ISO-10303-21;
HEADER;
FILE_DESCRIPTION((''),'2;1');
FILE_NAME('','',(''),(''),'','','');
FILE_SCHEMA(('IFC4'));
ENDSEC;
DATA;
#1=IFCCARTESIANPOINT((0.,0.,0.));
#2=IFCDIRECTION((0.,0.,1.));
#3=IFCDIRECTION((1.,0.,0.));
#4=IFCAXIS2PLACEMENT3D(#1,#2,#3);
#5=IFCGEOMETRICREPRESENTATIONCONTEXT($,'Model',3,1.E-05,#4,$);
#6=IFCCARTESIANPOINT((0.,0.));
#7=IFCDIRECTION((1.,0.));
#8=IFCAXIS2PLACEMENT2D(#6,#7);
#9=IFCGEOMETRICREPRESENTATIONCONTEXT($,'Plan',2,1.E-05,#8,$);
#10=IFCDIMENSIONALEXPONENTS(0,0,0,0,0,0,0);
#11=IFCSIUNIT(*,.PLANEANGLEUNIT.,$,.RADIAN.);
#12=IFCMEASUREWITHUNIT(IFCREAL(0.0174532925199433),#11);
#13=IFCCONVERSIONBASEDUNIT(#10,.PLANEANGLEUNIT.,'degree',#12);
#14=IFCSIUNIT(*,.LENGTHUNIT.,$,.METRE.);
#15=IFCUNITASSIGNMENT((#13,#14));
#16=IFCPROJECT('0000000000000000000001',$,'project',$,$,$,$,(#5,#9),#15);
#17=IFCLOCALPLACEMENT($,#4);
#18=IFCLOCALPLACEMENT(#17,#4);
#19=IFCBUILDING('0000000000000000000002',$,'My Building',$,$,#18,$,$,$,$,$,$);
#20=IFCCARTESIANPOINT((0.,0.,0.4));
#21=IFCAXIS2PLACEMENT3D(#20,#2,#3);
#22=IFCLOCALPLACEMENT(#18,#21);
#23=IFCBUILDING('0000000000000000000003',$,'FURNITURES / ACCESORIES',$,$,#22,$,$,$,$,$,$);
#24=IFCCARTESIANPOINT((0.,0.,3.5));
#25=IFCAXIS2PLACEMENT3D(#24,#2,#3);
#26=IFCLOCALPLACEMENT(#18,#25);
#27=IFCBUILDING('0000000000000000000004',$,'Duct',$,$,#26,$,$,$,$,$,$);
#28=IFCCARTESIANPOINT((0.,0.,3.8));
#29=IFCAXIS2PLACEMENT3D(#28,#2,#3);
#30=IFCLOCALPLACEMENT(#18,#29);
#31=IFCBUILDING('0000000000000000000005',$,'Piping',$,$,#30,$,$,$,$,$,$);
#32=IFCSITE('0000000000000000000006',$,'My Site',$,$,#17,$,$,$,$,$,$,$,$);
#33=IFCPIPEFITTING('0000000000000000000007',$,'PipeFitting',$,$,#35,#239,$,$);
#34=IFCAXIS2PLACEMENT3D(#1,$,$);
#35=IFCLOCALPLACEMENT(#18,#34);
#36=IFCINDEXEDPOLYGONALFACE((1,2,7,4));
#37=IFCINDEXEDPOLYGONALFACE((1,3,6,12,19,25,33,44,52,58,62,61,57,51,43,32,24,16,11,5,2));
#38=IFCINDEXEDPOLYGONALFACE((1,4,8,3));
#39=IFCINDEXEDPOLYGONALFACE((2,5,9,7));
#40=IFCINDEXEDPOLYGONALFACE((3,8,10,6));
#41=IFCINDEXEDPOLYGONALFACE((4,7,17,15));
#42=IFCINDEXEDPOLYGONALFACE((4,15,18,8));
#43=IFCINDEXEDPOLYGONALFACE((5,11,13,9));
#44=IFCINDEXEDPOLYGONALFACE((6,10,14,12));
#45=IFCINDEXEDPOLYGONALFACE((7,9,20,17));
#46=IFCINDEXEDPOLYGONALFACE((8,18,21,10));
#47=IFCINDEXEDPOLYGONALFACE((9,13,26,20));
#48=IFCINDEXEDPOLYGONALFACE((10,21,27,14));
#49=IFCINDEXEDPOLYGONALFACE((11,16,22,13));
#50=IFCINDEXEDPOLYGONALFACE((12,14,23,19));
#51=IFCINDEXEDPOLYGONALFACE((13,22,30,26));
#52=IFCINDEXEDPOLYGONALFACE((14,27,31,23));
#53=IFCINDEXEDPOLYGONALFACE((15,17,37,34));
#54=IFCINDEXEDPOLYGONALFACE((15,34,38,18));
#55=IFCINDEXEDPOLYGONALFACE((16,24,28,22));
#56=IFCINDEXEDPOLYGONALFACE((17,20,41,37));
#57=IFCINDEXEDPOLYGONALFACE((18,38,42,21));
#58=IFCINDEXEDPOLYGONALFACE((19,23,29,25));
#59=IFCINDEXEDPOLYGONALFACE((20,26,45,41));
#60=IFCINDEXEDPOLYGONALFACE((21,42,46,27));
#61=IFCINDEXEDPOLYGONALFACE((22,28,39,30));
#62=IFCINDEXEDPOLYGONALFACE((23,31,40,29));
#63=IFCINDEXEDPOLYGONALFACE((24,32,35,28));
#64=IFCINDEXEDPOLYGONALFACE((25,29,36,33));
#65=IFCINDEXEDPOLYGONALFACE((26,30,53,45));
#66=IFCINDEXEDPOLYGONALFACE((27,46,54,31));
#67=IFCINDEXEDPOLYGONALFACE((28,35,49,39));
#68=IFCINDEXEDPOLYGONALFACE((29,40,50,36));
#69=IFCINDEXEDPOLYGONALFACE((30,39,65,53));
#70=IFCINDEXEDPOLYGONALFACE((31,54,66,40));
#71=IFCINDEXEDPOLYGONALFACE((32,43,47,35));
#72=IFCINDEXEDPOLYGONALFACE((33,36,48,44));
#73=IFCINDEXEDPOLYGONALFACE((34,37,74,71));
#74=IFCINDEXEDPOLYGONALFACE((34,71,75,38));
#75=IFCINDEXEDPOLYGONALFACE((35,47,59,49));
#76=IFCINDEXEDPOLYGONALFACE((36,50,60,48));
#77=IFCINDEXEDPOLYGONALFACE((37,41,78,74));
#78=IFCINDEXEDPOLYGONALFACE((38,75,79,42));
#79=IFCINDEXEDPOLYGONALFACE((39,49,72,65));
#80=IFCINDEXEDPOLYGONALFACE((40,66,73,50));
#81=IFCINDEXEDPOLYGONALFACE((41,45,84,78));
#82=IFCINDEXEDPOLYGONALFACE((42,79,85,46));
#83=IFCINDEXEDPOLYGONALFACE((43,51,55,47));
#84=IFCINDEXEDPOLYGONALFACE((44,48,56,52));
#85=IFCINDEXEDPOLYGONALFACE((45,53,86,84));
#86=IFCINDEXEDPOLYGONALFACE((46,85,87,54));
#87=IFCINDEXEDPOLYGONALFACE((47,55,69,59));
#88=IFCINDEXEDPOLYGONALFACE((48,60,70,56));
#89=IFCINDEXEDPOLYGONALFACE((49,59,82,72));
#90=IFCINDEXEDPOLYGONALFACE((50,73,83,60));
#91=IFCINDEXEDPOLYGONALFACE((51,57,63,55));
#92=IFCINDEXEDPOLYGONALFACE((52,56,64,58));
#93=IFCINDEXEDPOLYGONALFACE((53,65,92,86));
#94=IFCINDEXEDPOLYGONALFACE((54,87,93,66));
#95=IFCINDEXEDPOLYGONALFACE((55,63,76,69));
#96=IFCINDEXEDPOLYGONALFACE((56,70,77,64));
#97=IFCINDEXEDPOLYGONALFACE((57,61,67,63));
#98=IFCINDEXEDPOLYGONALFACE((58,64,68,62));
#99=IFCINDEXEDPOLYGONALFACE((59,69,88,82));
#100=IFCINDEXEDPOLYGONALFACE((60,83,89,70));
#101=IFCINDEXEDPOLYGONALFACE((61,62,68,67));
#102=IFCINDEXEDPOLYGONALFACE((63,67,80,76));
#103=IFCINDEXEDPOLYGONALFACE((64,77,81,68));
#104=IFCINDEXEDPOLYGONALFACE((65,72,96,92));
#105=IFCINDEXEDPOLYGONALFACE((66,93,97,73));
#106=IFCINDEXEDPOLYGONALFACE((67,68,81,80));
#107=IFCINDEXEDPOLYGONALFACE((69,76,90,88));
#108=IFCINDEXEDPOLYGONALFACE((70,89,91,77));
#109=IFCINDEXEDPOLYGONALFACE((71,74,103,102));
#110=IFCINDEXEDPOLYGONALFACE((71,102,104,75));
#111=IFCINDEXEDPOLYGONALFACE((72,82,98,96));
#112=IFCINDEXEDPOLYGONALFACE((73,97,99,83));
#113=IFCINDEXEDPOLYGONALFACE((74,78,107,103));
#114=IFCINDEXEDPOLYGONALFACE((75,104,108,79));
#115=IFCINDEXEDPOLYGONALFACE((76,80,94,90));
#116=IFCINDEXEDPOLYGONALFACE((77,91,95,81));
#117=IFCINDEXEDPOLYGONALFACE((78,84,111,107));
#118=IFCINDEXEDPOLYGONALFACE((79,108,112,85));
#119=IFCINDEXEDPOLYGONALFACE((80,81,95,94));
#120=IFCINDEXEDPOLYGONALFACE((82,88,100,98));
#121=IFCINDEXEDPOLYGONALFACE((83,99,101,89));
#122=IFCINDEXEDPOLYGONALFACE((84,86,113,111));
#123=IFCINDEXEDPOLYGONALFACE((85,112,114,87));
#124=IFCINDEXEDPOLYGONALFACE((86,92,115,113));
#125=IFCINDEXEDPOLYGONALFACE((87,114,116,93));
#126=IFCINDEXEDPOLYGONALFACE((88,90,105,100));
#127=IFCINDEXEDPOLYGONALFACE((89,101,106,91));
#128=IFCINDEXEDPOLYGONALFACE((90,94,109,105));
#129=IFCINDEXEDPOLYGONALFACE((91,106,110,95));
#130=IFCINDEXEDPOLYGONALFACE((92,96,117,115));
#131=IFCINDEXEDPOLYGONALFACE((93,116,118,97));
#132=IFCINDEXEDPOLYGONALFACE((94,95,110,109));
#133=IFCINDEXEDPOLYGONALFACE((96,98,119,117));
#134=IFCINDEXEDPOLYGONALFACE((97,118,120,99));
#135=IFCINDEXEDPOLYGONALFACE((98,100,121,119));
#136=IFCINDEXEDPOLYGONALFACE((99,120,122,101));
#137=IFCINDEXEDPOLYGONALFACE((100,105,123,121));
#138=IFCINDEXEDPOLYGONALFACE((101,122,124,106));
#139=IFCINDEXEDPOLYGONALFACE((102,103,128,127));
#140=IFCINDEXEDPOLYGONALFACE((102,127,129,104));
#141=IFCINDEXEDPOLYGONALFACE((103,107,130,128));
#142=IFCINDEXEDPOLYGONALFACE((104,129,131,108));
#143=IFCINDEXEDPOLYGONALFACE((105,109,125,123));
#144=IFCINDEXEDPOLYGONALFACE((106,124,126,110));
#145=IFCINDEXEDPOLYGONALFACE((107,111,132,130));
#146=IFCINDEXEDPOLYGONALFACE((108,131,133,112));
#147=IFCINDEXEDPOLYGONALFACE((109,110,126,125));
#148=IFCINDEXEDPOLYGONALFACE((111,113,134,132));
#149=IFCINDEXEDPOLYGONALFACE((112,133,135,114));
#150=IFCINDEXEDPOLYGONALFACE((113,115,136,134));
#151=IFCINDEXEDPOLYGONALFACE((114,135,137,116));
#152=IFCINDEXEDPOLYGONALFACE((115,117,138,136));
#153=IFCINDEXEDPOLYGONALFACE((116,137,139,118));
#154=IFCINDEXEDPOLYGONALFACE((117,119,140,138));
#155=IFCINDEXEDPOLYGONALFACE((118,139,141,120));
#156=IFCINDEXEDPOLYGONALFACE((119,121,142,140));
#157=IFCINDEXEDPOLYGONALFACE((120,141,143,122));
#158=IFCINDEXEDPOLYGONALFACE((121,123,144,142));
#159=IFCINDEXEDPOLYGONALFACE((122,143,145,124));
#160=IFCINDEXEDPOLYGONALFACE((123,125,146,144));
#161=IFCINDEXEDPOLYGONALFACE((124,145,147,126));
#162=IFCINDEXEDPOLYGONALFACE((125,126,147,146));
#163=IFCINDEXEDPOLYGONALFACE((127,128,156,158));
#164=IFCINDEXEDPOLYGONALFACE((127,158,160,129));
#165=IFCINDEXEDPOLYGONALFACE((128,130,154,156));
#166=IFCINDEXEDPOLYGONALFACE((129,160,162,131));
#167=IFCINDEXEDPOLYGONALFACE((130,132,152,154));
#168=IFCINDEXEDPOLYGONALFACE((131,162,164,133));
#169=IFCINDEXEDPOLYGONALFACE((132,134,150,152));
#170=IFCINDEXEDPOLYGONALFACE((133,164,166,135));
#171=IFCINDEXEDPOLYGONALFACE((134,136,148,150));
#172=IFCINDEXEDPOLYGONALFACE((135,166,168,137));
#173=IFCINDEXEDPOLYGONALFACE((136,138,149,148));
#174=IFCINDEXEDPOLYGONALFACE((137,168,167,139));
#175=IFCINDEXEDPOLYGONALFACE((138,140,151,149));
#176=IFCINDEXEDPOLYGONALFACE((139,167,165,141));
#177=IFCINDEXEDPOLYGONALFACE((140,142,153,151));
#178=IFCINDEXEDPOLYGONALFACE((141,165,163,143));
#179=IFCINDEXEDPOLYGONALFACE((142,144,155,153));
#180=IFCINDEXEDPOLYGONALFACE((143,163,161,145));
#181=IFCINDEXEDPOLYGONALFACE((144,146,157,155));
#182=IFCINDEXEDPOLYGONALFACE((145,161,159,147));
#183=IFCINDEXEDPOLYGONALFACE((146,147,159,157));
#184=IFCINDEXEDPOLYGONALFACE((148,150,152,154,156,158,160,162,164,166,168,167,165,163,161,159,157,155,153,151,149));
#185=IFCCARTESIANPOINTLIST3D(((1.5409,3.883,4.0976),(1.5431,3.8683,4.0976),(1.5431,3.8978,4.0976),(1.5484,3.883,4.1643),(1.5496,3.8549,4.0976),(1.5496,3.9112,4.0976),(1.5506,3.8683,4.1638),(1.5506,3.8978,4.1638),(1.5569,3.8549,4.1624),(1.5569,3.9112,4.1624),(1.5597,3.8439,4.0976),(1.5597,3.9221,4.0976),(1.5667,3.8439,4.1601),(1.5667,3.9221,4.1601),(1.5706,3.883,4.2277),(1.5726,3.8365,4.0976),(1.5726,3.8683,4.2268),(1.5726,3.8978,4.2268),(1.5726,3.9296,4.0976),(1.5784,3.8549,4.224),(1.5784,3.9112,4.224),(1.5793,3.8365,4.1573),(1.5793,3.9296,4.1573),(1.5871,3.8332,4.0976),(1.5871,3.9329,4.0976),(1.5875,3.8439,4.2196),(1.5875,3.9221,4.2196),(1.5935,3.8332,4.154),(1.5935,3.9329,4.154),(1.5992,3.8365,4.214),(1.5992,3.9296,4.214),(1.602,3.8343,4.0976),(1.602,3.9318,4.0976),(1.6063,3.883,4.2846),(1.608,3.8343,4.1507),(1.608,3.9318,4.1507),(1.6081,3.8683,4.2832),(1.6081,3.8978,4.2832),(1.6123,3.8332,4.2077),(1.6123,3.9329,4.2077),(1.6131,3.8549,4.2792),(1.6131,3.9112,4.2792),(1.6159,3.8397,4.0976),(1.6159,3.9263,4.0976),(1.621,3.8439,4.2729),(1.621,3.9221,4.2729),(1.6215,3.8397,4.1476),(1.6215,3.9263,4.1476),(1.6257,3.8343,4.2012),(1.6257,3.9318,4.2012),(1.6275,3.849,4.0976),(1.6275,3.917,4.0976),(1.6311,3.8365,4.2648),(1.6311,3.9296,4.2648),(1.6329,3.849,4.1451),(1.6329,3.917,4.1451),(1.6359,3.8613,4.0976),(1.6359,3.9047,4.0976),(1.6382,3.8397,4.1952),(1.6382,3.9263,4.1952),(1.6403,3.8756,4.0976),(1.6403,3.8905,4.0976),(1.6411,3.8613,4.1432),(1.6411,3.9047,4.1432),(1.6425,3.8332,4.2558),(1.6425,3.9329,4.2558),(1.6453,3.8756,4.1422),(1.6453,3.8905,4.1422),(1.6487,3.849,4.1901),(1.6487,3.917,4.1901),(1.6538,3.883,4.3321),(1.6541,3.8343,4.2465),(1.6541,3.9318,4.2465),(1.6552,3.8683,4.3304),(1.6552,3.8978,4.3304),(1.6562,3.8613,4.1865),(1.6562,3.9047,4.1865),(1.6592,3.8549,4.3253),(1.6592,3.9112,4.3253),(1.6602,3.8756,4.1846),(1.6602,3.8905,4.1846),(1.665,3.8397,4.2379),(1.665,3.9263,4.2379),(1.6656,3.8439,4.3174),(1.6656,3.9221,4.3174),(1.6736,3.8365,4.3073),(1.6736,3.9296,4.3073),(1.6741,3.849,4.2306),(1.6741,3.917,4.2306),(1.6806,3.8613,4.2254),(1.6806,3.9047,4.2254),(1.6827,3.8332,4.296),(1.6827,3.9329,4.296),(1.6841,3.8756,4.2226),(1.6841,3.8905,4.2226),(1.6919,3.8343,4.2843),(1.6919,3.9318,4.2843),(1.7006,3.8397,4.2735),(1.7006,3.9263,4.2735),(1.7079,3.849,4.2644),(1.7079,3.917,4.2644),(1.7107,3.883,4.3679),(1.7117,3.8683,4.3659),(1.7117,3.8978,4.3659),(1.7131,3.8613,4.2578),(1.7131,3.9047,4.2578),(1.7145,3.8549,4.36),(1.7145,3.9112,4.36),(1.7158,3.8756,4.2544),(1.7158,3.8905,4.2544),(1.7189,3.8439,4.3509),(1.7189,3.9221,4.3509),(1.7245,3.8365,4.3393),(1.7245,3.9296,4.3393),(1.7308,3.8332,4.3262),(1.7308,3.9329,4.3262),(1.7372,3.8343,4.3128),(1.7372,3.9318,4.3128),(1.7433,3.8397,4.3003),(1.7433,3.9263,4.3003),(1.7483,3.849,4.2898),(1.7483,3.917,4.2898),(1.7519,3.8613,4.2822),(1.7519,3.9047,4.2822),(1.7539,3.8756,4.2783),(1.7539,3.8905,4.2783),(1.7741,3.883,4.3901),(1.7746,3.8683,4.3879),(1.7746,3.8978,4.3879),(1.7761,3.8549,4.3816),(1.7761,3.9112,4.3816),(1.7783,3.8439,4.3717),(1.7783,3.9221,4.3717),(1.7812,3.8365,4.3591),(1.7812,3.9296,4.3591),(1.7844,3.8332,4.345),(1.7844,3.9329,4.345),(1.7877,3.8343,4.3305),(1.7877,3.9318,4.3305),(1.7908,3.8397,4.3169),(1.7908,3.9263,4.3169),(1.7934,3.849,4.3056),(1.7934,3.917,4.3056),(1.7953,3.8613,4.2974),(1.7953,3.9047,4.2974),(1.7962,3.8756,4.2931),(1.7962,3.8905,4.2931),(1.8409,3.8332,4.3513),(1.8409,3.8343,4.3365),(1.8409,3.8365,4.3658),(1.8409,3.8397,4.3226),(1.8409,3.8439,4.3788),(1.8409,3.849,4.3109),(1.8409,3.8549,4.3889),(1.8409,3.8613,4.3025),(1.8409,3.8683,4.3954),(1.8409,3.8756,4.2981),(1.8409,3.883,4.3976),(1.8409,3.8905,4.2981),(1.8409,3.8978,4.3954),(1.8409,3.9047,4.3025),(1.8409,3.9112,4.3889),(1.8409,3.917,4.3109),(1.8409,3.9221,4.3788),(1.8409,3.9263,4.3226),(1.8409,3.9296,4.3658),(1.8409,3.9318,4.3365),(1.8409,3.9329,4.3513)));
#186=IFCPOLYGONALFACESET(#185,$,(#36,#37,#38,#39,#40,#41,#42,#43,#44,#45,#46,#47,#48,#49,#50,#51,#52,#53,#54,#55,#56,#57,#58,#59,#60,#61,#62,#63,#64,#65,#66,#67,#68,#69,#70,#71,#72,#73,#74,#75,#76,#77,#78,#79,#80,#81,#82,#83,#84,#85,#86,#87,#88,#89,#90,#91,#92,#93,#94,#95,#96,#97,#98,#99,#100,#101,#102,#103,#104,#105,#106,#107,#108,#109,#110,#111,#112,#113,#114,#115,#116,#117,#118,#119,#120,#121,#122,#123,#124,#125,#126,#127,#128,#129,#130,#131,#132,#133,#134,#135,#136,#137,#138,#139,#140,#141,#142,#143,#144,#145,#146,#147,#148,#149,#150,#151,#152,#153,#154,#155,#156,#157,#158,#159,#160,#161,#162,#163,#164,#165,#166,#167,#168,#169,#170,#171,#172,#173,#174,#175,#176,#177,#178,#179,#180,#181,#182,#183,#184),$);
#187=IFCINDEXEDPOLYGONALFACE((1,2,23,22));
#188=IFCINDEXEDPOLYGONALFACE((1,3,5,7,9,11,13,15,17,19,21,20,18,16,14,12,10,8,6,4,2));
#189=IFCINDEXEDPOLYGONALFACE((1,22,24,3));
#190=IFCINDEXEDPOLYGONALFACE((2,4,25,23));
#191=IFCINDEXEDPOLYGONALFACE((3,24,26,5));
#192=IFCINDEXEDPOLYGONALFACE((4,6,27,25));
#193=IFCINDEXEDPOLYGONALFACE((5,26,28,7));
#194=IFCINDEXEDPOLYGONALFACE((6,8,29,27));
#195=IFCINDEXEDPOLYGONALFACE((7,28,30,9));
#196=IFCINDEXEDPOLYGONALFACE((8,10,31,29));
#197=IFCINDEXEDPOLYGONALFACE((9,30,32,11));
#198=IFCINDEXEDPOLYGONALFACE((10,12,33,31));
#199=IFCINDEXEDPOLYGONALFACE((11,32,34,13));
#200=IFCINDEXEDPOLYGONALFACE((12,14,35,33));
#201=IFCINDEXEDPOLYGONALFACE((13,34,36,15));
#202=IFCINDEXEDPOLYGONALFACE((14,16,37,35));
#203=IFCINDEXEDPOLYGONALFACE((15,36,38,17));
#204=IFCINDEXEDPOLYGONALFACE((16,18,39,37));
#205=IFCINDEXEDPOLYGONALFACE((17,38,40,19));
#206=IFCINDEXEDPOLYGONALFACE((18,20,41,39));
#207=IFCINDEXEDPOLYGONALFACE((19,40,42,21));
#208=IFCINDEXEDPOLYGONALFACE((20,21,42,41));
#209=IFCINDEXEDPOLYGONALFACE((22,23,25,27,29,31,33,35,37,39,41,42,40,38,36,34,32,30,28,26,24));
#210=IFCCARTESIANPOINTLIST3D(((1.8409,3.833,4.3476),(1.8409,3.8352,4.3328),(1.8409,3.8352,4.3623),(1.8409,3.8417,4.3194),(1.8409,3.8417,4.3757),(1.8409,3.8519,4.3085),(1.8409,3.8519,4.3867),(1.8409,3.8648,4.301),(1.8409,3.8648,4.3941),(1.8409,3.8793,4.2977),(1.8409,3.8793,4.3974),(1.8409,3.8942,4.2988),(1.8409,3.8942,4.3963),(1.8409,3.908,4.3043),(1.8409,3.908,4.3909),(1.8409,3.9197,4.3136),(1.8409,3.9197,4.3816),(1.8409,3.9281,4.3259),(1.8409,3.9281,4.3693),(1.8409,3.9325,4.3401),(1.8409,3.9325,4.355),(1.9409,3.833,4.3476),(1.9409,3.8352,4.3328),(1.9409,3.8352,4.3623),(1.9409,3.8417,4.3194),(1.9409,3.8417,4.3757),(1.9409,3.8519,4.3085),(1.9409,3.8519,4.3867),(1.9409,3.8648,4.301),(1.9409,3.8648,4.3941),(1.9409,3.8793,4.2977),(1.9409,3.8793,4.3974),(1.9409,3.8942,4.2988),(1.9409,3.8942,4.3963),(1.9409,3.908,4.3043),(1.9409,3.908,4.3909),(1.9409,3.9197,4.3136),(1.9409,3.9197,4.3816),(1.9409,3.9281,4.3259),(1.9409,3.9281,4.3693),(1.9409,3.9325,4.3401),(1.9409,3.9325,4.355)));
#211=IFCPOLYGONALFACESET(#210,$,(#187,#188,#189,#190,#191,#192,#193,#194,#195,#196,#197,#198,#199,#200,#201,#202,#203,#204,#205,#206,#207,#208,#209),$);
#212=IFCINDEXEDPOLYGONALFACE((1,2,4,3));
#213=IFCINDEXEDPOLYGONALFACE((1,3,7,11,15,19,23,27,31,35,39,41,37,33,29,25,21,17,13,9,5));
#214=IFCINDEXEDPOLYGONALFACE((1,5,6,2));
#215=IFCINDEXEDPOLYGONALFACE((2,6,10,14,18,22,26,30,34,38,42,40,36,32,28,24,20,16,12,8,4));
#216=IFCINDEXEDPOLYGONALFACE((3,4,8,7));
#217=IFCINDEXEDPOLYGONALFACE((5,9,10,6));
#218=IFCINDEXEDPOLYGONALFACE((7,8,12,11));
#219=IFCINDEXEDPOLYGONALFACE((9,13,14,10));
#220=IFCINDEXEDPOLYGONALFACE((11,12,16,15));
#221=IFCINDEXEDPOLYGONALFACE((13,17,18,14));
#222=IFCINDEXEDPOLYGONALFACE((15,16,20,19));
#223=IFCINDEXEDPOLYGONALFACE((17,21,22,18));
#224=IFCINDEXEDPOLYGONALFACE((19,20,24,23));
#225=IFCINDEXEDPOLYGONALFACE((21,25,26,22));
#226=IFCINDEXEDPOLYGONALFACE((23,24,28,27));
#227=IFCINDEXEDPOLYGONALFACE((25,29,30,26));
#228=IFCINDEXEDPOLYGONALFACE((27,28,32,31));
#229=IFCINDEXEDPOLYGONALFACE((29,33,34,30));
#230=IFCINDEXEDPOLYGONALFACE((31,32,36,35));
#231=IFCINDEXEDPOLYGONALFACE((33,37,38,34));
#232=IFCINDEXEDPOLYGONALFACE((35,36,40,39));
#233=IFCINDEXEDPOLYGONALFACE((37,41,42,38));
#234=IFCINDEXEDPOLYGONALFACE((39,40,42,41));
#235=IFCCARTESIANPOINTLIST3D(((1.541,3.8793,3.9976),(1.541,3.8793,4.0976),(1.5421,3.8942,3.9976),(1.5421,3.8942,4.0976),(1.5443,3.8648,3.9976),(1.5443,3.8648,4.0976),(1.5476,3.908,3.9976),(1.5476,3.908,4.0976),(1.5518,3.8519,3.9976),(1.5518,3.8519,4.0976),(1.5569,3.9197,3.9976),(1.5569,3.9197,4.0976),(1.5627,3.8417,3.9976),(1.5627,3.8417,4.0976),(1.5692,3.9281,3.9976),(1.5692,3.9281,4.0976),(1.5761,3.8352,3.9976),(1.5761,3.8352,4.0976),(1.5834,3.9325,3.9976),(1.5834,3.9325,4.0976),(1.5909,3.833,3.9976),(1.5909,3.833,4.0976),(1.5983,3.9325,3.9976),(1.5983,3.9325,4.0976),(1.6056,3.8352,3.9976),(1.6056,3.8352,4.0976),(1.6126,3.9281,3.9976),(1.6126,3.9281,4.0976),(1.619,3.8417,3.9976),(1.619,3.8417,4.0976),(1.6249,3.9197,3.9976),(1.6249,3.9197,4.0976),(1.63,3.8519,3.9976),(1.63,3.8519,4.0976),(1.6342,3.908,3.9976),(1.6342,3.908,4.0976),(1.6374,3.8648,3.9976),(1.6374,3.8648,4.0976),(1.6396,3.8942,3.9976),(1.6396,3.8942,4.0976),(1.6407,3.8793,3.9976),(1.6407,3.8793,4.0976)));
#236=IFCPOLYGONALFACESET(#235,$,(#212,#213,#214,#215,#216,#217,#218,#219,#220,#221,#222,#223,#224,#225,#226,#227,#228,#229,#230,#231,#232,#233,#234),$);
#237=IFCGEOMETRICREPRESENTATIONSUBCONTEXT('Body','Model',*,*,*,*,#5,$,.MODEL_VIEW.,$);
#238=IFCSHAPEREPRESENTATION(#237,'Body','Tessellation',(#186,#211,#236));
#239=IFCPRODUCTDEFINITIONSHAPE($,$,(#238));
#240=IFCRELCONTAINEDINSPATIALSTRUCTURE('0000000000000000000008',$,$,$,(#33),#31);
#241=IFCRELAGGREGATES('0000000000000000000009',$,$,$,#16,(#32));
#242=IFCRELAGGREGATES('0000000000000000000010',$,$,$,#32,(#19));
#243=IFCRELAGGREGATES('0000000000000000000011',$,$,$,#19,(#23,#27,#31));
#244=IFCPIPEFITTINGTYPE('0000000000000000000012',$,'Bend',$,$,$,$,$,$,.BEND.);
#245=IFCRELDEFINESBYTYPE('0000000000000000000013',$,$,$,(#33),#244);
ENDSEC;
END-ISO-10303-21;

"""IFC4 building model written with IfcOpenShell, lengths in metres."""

from ifc_helpers import new_model, entity, si_unit, converted_unit, frame, origin_with_axes, origin_2d_with_axis, place, context, subcontext, project, spatial, circle, extrude, source, transform, mapped, type_object, type_shapes, element, save


model = new_model("IFC4")

# Units and contexts
model_context = context("Model", 3, precision=1e-05, world=origin_with_axes())
plan_context = context("Plan", 2, precision=1e-05, world=origin_2d_with_axis())
body_context = subcontext(model_context, "Body", "Model", "MODEL_VIEW")
ifc_project = project(units=[converted_unit("PLANEANGLEUNIT", "degree", entity("IfcReal", 0.0174532925199433), si_unit("PLANEANGLEUNIT", "RADIAN"), dimensions=[0, 0, 0, 0, 0, 0, 0]), si_unit("LENGTHUNIT", "METRE")], contexts=[model_context, plan_context])

# Site, building
site_placement = place(None, origin_with_axes())
site = spatial("IfcSite", under=ifc_project, at=site_placement, Name="My Site")
building_1_placement = place(site_placement, origin_with_axes())
building_1 = spatial("IfcBuilding", under=site, at=building_1_placement, Name="My Building")

# Shared definitions
building_2_placement = place(building_1_placement, frame((0.0, 0.0, 0.4), z_axis=(0.0, 0.0, 1.0), x_axis=(1.0, 0.0, 0.0)))
building_2 = spatial("IfcBuilding", under=building_1, at=building_2_placement, Name="FURNITURES / ACCESORIES")

# Shared definitions
building_3_placement = place(building_1_placement, frame((0.0, 0.0, 3.5), z_axis=(0.0, 0.0, 1.0), x_axis=(1.0, 0.0, 0.0)))
building_3 = spatial("IfcBuilding", under=building_1, at=building_3_placement, Name="Duct")

# Shared definitions
building_4_placement = place(building_1_placement, frame((0.0, 0.0, 3.8), z_axis=(0.0, 0.0, 1.0), x_axis=(1.0, 0.0, 0.0)))
building_4 = spatial("IfcBuilding", under=building_1, at=building_4_placement, Name="Piping")

# Pipe fitting
pipe_fitting_type = type_object("IfcPipeFittingType", Name="Bend", PredefinedType="BEND")
shared_shape = source(origin_with_axes(), body_context, "Body", "SolidModel", [
    entity("IfcSweptDiskSolid", entity("IfcIndexedPolyCurve", entity("IfcCartesianPointList3D", [[0.0, 0.0, 0.1], [0.0, -0.0732, 0.2768], [0.0, -0.25, 0.35]]), [entity("IfcArcIndex", [1, 2, 3])]), 0.05),
    extrude(circle(Radius=0.05), origin_with_axes(), (0.0, 0.0, 1.0), 0.1),
    extrude(circle(Radius=0.05), frame((0.0, -0.25, 0.35), z_axis=(0.0, -1.0, -0.000001), x_axis=(1.0, 0.0, 0.0)), (0.0, 0.0, 1.0), 0.1),
])
type_shapes(pipe_fitting_type, [shared_shape])
for number, where, z_axis, x_axis, name in (
    (1, (1.9409, 3.883, 0.5476), (-1.0, 0.000001, -0.000001), (-0.000001, -1.0, 0.0), "PipeFitting"),
):
    element("IfcPipeFitting", number, at=place(building_4_placement, frame(where, z_axis=z_axis, x_axis=x_axis)), inside=building_4, type_object=pipe_fitting_type, Name=name, context=body_context, shape_type="MappedRepresentation", body=[
        mapped(shared_shape, transform((0.0, 0.0, 0.0), x_axis=(1.0, 0.0, 0.0), y_axis=(0.0, 1.0, 0.0), z_axis=(0.0, 0.0, 1.0), scale=1.0)),
    ])

save(model, "model.ifc")
